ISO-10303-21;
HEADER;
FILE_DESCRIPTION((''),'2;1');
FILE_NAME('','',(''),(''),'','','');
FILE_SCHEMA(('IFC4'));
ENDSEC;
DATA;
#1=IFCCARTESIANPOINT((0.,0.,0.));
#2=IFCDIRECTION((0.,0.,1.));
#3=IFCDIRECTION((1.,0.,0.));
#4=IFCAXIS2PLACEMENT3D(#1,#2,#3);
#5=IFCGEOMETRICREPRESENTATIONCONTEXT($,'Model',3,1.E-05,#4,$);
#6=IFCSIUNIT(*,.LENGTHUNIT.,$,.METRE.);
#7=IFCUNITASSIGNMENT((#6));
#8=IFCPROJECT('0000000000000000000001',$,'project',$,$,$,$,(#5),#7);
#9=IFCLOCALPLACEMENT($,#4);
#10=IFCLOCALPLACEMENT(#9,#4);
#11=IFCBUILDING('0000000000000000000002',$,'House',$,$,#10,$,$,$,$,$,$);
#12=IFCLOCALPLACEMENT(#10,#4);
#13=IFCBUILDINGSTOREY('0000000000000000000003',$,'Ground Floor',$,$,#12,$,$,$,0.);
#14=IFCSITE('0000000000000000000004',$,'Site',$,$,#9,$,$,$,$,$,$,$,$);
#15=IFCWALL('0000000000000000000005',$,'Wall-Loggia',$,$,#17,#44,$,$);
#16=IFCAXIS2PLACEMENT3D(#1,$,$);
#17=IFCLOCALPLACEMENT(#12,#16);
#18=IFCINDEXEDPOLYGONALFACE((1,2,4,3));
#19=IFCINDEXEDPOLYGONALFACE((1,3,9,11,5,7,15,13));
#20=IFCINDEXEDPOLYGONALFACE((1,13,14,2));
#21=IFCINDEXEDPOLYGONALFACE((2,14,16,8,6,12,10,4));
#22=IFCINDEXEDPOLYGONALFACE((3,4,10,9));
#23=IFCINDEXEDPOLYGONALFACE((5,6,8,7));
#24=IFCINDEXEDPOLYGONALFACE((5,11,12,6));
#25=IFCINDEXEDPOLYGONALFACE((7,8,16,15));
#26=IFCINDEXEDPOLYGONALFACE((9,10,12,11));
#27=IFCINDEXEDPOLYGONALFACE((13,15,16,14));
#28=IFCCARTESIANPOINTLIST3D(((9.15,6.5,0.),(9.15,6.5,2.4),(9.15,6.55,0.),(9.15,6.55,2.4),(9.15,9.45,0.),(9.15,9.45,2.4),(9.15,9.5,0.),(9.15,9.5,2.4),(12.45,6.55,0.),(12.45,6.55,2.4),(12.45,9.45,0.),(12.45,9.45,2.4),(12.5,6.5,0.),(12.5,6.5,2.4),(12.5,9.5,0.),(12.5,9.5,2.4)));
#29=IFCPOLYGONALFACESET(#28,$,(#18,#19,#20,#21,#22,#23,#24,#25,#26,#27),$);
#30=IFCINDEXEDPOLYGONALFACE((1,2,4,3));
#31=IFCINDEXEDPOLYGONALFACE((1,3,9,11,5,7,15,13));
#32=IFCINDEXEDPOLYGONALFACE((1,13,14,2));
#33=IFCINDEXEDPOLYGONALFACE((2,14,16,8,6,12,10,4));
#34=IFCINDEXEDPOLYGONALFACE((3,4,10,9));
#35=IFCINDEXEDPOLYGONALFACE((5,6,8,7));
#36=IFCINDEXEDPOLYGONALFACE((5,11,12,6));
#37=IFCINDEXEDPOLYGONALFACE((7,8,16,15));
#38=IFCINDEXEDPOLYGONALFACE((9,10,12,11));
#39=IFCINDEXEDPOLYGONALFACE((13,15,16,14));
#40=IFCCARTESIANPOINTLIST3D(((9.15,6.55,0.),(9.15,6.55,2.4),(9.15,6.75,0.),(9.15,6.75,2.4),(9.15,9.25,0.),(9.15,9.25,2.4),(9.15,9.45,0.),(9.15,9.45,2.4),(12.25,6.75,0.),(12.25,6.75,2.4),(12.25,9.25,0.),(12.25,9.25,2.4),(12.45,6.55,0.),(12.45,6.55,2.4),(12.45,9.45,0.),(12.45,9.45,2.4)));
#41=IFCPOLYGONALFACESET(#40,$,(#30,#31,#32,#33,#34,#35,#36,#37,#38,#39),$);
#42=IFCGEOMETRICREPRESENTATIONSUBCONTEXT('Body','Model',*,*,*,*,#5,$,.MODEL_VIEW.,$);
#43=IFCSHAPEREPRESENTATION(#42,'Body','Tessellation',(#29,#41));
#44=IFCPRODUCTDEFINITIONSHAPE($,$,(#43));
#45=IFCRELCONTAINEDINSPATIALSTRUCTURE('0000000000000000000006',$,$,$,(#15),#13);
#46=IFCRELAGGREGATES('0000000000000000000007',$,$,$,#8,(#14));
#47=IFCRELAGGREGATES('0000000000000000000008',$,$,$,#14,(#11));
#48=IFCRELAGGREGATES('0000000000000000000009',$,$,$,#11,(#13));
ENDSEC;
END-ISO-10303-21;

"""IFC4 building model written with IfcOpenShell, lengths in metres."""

from ifc_helpers import new_model, si_unit, origin, origin_with_axes, place, context, subcontext, project, spatial, polyline, outline, extrude, element, save


model = new_model("IFC4")

# Units and contexts
model_context = context("Model", 3, precision=1e-05, world=origin_with_axes())
body_context = subcontext(model_context, "Body", "Model", "MODEL_VIEW")
ifc_project = project(units=[si_unit("LENGTHUNIT", "METRE")], contexts=[model_context])

# Site, building, storey
site_placement = place(None, origin_with_axes())
site = spatial("IfcSite", under=ifc_project, at=site_placement, Name="Site")
building_placement = place(site_placement, origin_with_axes())
building = spatial("IfcBuilding", under=site, at=building_placement, Name="House")
storey_placement = place(building_placement, origin_with_axes())
storey = spatial("IfcBuildingStorey", under=building, at=storey_placement, Name="Ground Floor", Elevation=0.0)

# Wall
wall_placement = place(storey_placement, origin_with_axes())
element("IfcWall", 1, at=wall_placement, inside=storey, Name="Wall-Loggia", context=body_context, shape_type="SweptSolid", body=[
    extrude(outline(polyline([(9.15, 6.5), (12.5, 6.5), (12.5, 9.5), (9.15, 9.5), (9.15, 9.45), (12.45, 9.45), (12.45, 6.55), (9.15, 6.55), (9.15, 6.5)])), origin(), (0.0, 0.0, 1.0), 2.4),
    extrude(outline(polyline([(9.15, 6.55), (12.45, 6.55), (12.45, 9.45), (9.15, 9.45), (9.15, 9.25), (12.25, 9.25), (12.25, 6.75), (9.15, 6.75), (9.15, 6.55)])), origin(), (0.0, 0.0, 1.0), 2.4),
])

save(model, "model.ifc")
